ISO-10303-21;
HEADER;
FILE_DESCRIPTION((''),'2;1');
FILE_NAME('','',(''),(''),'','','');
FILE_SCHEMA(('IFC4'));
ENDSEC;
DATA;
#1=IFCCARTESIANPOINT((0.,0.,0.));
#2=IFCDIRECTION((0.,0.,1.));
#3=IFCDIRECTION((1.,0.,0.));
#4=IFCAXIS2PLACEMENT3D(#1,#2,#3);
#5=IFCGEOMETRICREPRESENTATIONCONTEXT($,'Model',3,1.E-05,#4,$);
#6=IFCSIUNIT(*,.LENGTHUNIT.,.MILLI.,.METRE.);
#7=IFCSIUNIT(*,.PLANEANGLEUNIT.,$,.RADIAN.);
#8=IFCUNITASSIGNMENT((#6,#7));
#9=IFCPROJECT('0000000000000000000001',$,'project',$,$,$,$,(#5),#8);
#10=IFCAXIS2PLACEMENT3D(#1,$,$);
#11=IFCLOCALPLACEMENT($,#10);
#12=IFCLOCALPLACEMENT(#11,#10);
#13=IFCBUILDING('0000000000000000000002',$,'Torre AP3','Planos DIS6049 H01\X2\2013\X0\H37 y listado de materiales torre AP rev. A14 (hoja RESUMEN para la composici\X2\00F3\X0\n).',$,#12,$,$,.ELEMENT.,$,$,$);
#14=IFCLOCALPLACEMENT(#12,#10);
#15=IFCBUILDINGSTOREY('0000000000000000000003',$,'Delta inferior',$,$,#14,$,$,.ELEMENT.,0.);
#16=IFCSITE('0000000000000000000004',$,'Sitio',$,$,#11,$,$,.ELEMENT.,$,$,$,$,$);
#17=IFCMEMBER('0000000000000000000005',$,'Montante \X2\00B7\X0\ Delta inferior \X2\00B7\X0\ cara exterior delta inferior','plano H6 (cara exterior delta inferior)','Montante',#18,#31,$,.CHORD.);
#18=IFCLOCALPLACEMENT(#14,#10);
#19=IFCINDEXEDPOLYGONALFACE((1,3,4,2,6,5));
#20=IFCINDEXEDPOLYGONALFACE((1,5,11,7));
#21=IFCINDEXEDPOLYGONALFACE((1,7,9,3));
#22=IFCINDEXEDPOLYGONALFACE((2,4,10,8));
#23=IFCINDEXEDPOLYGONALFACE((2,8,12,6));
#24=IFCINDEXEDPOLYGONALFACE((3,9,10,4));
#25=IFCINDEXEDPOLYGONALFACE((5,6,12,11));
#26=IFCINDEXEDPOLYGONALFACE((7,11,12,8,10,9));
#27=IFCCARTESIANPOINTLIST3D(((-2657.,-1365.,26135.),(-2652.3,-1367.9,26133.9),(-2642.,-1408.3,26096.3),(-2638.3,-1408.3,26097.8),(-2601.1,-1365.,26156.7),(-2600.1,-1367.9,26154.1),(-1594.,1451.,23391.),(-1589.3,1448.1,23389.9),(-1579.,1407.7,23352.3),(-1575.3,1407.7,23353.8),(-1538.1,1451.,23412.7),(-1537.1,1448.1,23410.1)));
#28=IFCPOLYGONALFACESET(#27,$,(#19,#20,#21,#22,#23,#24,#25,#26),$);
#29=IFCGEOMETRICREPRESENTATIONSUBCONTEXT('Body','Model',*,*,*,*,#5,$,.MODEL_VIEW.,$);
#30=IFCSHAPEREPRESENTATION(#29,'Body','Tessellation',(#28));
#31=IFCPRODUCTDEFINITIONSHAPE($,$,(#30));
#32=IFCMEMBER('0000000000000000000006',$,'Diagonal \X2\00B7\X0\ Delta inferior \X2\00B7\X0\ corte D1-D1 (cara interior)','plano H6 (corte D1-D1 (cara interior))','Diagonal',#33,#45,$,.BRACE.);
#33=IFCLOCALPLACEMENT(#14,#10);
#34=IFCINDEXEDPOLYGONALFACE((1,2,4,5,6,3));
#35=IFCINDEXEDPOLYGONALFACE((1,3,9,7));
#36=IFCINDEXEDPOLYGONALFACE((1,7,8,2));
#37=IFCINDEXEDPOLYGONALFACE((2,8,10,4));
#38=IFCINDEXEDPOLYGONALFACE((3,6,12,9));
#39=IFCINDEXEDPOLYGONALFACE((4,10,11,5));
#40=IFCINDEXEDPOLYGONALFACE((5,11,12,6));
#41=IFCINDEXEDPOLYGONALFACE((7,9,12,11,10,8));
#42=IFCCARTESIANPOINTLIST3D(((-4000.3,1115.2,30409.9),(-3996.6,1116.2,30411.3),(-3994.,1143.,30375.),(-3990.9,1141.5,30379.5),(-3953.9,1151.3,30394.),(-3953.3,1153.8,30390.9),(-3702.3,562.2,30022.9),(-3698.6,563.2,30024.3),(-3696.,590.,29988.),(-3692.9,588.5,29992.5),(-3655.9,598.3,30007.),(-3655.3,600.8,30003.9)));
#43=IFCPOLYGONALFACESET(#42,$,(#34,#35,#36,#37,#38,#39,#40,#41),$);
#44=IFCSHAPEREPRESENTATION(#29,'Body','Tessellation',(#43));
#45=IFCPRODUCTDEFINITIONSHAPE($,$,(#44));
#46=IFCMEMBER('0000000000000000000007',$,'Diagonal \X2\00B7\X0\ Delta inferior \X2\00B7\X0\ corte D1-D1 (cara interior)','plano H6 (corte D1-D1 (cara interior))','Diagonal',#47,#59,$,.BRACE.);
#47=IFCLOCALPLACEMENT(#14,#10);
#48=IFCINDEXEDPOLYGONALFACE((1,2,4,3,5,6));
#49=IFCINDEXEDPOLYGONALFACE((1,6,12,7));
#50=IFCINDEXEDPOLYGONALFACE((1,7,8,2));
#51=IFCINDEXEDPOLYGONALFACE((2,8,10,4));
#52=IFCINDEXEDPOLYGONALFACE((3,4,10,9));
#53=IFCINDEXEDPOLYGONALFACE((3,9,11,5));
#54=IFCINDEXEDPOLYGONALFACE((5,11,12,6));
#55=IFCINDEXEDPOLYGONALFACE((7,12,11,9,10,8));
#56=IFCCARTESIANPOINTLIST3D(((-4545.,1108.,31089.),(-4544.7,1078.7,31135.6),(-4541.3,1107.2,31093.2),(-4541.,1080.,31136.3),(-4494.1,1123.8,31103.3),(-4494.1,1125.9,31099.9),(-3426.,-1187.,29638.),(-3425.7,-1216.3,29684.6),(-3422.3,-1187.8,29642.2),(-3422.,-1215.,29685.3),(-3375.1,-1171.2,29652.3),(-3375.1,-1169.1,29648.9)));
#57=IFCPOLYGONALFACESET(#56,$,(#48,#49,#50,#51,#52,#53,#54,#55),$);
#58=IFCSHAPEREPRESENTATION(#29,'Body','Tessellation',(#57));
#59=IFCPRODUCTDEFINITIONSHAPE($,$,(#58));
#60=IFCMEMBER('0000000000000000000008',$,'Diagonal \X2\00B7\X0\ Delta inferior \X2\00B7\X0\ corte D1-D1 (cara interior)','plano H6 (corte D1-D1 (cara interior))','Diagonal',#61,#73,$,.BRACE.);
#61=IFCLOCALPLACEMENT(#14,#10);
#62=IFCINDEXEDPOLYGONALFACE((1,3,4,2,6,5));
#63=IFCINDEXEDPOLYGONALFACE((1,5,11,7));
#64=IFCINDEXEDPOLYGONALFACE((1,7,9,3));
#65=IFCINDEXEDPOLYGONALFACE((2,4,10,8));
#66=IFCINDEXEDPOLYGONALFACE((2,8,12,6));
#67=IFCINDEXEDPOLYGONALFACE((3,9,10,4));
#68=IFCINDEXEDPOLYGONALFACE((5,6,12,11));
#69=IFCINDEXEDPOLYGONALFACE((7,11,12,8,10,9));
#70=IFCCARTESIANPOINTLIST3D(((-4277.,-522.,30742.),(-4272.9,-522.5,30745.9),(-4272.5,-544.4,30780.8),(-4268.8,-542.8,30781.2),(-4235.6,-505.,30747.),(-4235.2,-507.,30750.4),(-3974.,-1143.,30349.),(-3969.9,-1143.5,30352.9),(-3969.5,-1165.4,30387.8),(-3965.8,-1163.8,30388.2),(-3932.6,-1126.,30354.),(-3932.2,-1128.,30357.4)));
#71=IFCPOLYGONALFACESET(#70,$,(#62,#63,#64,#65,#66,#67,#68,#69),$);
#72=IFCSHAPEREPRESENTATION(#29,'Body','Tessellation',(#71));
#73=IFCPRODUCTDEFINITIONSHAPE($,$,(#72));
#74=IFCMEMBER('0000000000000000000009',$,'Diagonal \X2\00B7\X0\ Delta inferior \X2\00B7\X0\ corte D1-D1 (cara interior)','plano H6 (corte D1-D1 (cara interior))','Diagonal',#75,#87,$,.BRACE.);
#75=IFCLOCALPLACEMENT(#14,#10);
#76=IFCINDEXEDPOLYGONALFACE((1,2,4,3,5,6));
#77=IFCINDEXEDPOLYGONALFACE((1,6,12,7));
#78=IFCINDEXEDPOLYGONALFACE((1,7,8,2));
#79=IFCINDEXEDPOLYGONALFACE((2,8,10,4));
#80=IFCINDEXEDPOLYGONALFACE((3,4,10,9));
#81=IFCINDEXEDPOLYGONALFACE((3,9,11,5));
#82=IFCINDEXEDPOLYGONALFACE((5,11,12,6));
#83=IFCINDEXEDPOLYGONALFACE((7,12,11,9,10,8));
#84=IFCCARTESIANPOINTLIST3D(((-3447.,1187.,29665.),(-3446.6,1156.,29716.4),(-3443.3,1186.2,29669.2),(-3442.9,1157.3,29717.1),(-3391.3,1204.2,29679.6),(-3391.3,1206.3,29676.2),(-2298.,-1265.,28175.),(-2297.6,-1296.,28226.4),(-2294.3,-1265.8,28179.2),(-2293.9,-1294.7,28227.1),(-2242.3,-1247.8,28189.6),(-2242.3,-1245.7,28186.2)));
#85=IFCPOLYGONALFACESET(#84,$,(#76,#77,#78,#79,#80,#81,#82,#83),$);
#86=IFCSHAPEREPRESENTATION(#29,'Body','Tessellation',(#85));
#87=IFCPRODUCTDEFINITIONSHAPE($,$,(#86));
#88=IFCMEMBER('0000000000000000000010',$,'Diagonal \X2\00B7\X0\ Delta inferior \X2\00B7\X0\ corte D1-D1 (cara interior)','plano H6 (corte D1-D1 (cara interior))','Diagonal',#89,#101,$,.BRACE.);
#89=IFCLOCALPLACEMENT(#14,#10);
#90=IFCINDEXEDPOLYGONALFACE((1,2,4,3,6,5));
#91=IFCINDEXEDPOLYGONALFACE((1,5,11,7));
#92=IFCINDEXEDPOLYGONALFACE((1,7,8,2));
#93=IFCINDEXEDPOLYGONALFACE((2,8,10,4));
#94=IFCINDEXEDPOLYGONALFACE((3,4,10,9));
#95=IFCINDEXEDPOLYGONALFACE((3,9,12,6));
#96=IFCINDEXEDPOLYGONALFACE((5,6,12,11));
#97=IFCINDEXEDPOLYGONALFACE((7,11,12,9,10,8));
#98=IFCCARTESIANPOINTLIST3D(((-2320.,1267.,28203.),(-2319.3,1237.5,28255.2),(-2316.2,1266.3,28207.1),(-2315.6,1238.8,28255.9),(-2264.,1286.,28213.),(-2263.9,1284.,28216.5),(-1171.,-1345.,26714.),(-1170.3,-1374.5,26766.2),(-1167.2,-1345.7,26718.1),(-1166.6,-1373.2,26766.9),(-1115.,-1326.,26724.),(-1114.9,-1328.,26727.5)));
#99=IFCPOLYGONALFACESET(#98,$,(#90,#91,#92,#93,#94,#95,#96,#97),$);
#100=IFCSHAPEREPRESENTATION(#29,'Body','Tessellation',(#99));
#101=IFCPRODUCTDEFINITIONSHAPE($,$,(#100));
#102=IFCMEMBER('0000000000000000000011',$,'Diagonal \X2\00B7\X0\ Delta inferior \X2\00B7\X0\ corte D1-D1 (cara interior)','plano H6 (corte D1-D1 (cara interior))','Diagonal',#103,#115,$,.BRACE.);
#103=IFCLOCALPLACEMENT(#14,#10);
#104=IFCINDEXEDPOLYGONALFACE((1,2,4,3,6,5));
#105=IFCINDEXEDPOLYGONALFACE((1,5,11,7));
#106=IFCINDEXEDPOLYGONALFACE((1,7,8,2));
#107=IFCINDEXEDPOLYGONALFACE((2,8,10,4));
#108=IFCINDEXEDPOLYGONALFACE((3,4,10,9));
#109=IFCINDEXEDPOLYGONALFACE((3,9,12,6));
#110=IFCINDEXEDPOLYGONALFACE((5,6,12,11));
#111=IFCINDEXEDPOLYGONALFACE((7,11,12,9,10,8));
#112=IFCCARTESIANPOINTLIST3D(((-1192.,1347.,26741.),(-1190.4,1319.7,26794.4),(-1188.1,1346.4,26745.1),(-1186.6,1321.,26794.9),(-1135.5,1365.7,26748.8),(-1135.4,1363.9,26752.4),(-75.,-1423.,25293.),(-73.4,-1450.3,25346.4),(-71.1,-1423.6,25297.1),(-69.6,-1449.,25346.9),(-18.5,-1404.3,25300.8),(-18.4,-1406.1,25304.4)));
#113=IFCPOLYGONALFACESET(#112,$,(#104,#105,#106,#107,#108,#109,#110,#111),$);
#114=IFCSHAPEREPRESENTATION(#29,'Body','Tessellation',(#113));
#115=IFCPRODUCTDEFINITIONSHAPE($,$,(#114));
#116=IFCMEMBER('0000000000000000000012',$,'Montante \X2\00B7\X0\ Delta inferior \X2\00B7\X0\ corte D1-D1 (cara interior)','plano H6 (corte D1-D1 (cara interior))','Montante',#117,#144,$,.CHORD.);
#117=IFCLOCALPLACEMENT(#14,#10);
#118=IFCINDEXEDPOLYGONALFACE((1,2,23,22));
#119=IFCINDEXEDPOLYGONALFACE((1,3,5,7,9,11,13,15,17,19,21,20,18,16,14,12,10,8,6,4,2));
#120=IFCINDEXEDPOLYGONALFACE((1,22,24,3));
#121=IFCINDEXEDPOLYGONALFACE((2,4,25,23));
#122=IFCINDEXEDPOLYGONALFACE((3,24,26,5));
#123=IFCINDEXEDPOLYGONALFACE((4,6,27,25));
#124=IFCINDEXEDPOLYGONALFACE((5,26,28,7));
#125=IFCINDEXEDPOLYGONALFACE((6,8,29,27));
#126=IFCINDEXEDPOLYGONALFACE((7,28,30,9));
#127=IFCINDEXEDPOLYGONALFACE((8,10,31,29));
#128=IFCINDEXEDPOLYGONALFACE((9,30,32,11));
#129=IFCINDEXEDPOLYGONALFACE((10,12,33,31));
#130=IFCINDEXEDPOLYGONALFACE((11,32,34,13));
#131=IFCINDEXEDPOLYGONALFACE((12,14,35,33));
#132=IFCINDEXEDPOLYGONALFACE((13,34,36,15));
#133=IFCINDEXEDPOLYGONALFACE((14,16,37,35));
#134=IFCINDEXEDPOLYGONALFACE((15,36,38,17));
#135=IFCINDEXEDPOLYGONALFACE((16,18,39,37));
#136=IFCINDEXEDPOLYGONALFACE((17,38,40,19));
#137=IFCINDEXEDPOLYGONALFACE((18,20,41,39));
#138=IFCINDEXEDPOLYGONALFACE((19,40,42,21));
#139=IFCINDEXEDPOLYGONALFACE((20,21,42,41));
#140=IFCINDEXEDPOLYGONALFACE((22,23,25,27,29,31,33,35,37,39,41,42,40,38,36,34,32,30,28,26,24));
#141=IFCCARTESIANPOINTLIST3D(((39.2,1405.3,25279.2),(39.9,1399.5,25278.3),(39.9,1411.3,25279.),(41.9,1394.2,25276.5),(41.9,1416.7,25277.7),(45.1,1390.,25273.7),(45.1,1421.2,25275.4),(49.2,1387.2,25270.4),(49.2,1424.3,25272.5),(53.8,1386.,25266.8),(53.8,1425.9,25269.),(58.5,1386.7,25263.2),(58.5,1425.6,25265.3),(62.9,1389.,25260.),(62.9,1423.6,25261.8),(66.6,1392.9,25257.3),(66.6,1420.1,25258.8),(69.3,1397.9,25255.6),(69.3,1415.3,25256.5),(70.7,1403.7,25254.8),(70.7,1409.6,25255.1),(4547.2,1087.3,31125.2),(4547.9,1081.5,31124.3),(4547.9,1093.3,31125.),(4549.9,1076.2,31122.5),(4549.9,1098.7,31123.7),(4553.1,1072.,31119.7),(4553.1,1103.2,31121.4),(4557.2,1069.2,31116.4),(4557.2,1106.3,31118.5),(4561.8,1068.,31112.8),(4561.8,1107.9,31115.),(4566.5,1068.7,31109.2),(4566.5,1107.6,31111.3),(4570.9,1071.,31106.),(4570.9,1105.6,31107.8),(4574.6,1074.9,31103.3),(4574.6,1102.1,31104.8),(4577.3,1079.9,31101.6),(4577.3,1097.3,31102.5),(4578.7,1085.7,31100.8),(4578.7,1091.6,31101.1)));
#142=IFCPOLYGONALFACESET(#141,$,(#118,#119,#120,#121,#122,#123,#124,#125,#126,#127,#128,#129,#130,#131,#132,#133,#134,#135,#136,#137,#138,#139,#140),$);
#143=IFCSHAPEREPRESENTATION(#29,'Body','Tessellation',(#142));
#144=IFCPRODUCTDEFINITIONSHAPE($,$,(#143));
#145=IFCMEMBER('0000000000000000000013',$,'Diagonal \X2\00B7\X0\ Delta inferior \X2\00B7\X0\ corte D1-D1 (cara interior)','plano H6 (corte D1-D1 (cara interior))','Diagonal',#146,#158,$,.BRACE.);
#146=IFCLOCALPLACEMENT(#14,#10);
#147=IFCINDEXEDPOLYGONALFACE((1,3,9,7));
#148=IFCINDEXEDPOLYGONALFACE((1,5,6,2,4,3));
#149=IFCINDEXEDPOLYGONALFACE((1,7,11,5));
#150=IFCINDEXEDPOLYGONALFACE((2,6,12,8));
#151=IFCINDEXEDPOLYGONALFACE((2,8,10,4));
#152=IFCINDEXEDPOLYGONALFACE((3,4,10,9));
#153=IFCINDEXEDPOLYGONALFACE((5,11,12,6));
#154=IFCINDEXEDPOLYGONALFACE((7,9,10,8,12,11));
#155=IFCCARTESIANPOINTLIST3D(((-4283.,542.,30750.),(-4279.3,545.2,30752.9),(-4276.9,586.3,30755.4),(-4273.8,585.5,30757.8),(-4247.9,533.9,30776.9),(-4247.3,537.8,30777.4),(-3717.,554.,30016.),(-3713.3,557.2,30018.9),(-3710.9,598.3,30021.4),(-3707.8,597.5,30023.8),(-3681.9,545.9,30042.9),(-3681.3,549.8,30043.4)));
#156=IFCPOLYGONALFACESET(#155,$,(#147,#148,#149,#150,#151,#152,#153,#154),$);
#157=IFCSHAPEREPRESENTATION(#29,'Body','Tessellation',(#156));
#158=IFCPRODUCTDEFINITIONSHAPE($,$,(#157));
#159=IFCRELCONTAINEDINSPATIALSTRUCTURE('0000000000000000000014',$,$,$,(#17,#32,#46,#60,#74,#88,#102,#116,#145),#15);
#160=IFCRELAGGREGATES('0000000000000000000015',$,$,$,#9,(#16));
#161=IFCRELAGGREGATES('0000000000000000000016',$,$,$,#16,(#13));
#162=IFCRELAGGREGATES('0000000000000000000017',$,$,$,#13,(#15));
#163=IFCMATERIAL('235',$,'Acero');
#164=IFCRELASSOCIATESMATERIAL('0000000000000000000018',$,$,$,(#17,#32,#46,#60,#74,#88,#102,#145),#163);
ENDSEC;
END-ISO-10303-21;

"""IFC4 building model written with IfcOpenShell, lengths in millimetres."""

from ifc_helpers import new_model, si_unit, frame, frame_2d, origin, origin_with_axes, place, context, subcontext, project, spatial, circle, l_section, extrude, material, element, save


model = new_model("IFC4")

# Units and contexts
model_context = context("Model", 3, precision=1e-05, world=origin_with_axes())
body_context = subcontext(model_context, "Body", "Model", "MODEL_VIEW")
ifc_project = project(units=[si_unit("LENGTHUNIT", "METRE", prefix="MILLI"), si_unit("PLANEANGLEUNIT", "RADIAN")], contexts=[model_context])

# Site, building, storey
site_placement = place(None, origin())
site = spatial("IfcSite", under=ifc_project, at=site_placement, Name="Sitio", CompositionType="ELEMENT")
building_placement = place(site_placement, origin())
building = spatial("IfcBuilding", under=site, at=building_placement, Name="Torre AP3", Description="Planos DIS6049 H01–H37 y listado de materiales torre AP rev. A14 (hoja RESUMEN para la composición).", CompositionType="ELEMENT")
storey_placement = place(building_placement, origin())
storey = spatial("IfcBuildingStorey", under=building, at=storey_placement, Name="Delta inferior", CompositionType="ELEMENT", Elevation=0.0)

# Members
ifc_material_1 = material(Name="235", Category="Acero")
member_1_placement = place(storey_placement, frame((-1594.0, 1451.0, 23391.0), z_axis=(-0.260987, -0.691382, 0.673704), x_axis=(0.249749, -0.72249, -0.644697)))
element("IfcMember", 1, at=member_1_placement, inside=storey, material=ifc_material_1, Name="Montante · Delta inferior · cara exterior delta inferior", Description="plano H6 (cara exterior delta inferior)", ObjectType="Montante", PredefinedType="CHORD", context=body_context, shape_type="SweptSolid", body=[
    extrude(l_section(Depth=60.0, Width=60.0, Thickness=4.0, at=frame_2d((30.0, 30.0))), None, (0.0, 0.0, 1.0), 4073.0),
])
member_2_placement = place(storey_placement, frame((-3994.0, 1143.0, 30375.0), z_axis=(0.403891, -0.749503, -0.524516), x_axis=(0.904178, 0.239916, 0.353414)))
element("IfcMember", 2, at=member_2_placement, inside=storey, material=ifc_material_1, Name="Diagonal · Delta inferior · corte D1-D1 (cara interior)", Description="plano H6 (corte D1-D1 (cara interior))", ObjectType="Diagonal", PredefinedType="BRACE", context=body_context, shape_type="SweptSolid", body=[
    extrude(l_section(Depth=45.0, Width=45.0, Thickness=4.0, at=frame_2d((22.5, 22.5))), None, (0.0, 0.0, 1.0), 737.8),
])
member_3_placement = place(storey_placement, frame((-4545.0, 1108.0, 31089.0), z_axis=(0.381032, -0.781472, -0.494081), x_axis=(0.924547, 0.325107, 0.198793)))
element("IfcMember", 3, at=member_3_placement, inside=storey, material=ifc_material_1, Name="Diagonal · Delta inferior · corte D1-D1 (cara interior)", Description="plano H6 (corte D1-D1 (cara interior))", ObjectType="Diagonal", PredefinedType="BRACE", context=body_context, shape_type="SweptSolid", body=[
    extrude(l_section(Depth=55.0, Width=55.0, Thickness=4.0, at=frame_2d((27.5, 27.5))), None, (0.0, 0.0, 1.0), 2936.8),
])
member_4_placement = place(storey_placement, frame((-4277.0, -522.0, 30742.0), z_axis=(0.38117, -0.78121, -0.494389), x_axis=(0.919056, 0.378167, 0.111023)))
element("IfcMember", 4, at=member_4_placement, inside=storey, material=ifc_material_1, Name="Diagonal · Delta inferior · corte D1-D1 (cara interior)", Description="plano H6 (corte D1-D1 (cara interior))", ObjectType="Diagonal", PredefinedType="BRACE", context=body_context, shape_type="SweptSolid", body=[
    extrude(l_section(Depth=45.0, Width=45.0, Thickness=4.0, at=frame_2d((22.5, 22.5))), None, (0.0, 0.0, 1.0), 794.9),
])
member_5_placement = place(storey_placement, frame((-3447.0, 1187.0, 29665.0), z_axis=(0.371757, -0.79334, -0.482087), x_axis=(0.928304, 0.321616, 0.18659)))
element("IfcMember", 5, at=member_5_placement, inside=storey, material=ifc_material_1, Name="Diagonal · Delta inferior · corte D1-D1 (cara interior)", Description="plano H6 (corte D1-D1 (cara interior))", ObjectType="Diagonal", PredefinedType="BRACE", context=body_context, shape_type="SweptSolid", body=[
    extrude(l_section(Depth=60.0, Width=60.0, Thickness=4.0, at=frame_2d((30.0, 30.0))), None, (0.0, 0.0, 1.0), 3090.7),
])
member_6_placement = place(storey_placement, frame((-2320.0, 1267.0, 28203.0), z_axis=(0.356979, -0.811514, -0.462613), x_axis=(0.934048, 0.315929, 0.166565)))
element("IfcMember", 6, at=member_6_placement, inside=storey, material=ifc_material_1, Name="Diagonal · Delta inferior · corte D1-D1 (cara interior)", Description="plano H6 (corte D1-D1 (cara interior))", ObjectType="Diagonal", PredefinedType="BRACE", context=body_context, shape_type="SweptSolid", body=[
    extrude(l_section(Depth=60.0, Width=60.0, Thickness=4.0, at=frame_2d((30.0, 30.0))), None, (0.0, 0.0, 1.0), 3218.7),
])
member_7_placement = place(storey_placement, frame((-1192.0, 1347.0, 26741.0), z_axis=(0.336524, -0.834531, -0.436246), x_axis=(0.94128, 0.311519, 0.130181)))
element("IfcMember", 7, at=member_7_placement, inside=storey, material=ifc_material_1, Name="Diagonal · Delta inferior · corte D1-D1 (cara interior)", Description="plano H6 (corte D1-D1 (cara interior))", ObjectType="Diagonal", PredefinedType="BRACE", context=body_context, shape_type="SweptSolid", body=[
    extrude(l_section(Depth=60.0, Width=60.0, Thickness=4.0, at=frame_2d((30.0, 30.0))), None, (0.0, 0.0, 1.0), 3319.2),
])
for number, where, z_axis, x_axis, name in (
    (8, (55.0, 1406.0, 25267.0), (0.610087, -0.043036, 0.791165), (-0.792334, -0.033137, 0.609187), "Montante · Delta inferior · corte D1-D1 (cara interior)"),
):
    element("IfcMember", number, at=place(storey_placement, frame(where, z_axis=z_axis, x_axis=x_axis)), inside=storey, Name=name, Description="plano H6 (corte D1-D1 (cara interior))", ObjectType="Montante", PredefinedType="CHORD", context=body_context, shape_type="SweptSolid", body=[
        extrude(circle(Radius=20.0), None, (0.0, 0.0, 1.0), 7389.1),
    ])
member_8_placement = place(storey_placement, frame((-3717.0, 554.0, 30016.0), z_axis=(-0.610598, -0.012946, 0.791835), x_axis=(0.780393, -0.179966, 0.598832)))
element("IfcMember", 9, at=member_8_placement, inside=storey, material=ifc_material_1, Name="Diagonal · Delta inferior · corte D1-D1 (cara interior)", Description="plano H6 (corte D1-D1 (cara interior))", ObjectType="Diagonal", PredefinedType="BRACE", context=body_context, shape_type="SweptSolid", body=[
    extrude(l_section(Depth=45.0, Width=45.0, Thickness=4.0, at=frame_2d((22.5, 22.5))), None, (0.0, 0.0, 1.0), 927.0),
])

save(model, "model.ifc")
